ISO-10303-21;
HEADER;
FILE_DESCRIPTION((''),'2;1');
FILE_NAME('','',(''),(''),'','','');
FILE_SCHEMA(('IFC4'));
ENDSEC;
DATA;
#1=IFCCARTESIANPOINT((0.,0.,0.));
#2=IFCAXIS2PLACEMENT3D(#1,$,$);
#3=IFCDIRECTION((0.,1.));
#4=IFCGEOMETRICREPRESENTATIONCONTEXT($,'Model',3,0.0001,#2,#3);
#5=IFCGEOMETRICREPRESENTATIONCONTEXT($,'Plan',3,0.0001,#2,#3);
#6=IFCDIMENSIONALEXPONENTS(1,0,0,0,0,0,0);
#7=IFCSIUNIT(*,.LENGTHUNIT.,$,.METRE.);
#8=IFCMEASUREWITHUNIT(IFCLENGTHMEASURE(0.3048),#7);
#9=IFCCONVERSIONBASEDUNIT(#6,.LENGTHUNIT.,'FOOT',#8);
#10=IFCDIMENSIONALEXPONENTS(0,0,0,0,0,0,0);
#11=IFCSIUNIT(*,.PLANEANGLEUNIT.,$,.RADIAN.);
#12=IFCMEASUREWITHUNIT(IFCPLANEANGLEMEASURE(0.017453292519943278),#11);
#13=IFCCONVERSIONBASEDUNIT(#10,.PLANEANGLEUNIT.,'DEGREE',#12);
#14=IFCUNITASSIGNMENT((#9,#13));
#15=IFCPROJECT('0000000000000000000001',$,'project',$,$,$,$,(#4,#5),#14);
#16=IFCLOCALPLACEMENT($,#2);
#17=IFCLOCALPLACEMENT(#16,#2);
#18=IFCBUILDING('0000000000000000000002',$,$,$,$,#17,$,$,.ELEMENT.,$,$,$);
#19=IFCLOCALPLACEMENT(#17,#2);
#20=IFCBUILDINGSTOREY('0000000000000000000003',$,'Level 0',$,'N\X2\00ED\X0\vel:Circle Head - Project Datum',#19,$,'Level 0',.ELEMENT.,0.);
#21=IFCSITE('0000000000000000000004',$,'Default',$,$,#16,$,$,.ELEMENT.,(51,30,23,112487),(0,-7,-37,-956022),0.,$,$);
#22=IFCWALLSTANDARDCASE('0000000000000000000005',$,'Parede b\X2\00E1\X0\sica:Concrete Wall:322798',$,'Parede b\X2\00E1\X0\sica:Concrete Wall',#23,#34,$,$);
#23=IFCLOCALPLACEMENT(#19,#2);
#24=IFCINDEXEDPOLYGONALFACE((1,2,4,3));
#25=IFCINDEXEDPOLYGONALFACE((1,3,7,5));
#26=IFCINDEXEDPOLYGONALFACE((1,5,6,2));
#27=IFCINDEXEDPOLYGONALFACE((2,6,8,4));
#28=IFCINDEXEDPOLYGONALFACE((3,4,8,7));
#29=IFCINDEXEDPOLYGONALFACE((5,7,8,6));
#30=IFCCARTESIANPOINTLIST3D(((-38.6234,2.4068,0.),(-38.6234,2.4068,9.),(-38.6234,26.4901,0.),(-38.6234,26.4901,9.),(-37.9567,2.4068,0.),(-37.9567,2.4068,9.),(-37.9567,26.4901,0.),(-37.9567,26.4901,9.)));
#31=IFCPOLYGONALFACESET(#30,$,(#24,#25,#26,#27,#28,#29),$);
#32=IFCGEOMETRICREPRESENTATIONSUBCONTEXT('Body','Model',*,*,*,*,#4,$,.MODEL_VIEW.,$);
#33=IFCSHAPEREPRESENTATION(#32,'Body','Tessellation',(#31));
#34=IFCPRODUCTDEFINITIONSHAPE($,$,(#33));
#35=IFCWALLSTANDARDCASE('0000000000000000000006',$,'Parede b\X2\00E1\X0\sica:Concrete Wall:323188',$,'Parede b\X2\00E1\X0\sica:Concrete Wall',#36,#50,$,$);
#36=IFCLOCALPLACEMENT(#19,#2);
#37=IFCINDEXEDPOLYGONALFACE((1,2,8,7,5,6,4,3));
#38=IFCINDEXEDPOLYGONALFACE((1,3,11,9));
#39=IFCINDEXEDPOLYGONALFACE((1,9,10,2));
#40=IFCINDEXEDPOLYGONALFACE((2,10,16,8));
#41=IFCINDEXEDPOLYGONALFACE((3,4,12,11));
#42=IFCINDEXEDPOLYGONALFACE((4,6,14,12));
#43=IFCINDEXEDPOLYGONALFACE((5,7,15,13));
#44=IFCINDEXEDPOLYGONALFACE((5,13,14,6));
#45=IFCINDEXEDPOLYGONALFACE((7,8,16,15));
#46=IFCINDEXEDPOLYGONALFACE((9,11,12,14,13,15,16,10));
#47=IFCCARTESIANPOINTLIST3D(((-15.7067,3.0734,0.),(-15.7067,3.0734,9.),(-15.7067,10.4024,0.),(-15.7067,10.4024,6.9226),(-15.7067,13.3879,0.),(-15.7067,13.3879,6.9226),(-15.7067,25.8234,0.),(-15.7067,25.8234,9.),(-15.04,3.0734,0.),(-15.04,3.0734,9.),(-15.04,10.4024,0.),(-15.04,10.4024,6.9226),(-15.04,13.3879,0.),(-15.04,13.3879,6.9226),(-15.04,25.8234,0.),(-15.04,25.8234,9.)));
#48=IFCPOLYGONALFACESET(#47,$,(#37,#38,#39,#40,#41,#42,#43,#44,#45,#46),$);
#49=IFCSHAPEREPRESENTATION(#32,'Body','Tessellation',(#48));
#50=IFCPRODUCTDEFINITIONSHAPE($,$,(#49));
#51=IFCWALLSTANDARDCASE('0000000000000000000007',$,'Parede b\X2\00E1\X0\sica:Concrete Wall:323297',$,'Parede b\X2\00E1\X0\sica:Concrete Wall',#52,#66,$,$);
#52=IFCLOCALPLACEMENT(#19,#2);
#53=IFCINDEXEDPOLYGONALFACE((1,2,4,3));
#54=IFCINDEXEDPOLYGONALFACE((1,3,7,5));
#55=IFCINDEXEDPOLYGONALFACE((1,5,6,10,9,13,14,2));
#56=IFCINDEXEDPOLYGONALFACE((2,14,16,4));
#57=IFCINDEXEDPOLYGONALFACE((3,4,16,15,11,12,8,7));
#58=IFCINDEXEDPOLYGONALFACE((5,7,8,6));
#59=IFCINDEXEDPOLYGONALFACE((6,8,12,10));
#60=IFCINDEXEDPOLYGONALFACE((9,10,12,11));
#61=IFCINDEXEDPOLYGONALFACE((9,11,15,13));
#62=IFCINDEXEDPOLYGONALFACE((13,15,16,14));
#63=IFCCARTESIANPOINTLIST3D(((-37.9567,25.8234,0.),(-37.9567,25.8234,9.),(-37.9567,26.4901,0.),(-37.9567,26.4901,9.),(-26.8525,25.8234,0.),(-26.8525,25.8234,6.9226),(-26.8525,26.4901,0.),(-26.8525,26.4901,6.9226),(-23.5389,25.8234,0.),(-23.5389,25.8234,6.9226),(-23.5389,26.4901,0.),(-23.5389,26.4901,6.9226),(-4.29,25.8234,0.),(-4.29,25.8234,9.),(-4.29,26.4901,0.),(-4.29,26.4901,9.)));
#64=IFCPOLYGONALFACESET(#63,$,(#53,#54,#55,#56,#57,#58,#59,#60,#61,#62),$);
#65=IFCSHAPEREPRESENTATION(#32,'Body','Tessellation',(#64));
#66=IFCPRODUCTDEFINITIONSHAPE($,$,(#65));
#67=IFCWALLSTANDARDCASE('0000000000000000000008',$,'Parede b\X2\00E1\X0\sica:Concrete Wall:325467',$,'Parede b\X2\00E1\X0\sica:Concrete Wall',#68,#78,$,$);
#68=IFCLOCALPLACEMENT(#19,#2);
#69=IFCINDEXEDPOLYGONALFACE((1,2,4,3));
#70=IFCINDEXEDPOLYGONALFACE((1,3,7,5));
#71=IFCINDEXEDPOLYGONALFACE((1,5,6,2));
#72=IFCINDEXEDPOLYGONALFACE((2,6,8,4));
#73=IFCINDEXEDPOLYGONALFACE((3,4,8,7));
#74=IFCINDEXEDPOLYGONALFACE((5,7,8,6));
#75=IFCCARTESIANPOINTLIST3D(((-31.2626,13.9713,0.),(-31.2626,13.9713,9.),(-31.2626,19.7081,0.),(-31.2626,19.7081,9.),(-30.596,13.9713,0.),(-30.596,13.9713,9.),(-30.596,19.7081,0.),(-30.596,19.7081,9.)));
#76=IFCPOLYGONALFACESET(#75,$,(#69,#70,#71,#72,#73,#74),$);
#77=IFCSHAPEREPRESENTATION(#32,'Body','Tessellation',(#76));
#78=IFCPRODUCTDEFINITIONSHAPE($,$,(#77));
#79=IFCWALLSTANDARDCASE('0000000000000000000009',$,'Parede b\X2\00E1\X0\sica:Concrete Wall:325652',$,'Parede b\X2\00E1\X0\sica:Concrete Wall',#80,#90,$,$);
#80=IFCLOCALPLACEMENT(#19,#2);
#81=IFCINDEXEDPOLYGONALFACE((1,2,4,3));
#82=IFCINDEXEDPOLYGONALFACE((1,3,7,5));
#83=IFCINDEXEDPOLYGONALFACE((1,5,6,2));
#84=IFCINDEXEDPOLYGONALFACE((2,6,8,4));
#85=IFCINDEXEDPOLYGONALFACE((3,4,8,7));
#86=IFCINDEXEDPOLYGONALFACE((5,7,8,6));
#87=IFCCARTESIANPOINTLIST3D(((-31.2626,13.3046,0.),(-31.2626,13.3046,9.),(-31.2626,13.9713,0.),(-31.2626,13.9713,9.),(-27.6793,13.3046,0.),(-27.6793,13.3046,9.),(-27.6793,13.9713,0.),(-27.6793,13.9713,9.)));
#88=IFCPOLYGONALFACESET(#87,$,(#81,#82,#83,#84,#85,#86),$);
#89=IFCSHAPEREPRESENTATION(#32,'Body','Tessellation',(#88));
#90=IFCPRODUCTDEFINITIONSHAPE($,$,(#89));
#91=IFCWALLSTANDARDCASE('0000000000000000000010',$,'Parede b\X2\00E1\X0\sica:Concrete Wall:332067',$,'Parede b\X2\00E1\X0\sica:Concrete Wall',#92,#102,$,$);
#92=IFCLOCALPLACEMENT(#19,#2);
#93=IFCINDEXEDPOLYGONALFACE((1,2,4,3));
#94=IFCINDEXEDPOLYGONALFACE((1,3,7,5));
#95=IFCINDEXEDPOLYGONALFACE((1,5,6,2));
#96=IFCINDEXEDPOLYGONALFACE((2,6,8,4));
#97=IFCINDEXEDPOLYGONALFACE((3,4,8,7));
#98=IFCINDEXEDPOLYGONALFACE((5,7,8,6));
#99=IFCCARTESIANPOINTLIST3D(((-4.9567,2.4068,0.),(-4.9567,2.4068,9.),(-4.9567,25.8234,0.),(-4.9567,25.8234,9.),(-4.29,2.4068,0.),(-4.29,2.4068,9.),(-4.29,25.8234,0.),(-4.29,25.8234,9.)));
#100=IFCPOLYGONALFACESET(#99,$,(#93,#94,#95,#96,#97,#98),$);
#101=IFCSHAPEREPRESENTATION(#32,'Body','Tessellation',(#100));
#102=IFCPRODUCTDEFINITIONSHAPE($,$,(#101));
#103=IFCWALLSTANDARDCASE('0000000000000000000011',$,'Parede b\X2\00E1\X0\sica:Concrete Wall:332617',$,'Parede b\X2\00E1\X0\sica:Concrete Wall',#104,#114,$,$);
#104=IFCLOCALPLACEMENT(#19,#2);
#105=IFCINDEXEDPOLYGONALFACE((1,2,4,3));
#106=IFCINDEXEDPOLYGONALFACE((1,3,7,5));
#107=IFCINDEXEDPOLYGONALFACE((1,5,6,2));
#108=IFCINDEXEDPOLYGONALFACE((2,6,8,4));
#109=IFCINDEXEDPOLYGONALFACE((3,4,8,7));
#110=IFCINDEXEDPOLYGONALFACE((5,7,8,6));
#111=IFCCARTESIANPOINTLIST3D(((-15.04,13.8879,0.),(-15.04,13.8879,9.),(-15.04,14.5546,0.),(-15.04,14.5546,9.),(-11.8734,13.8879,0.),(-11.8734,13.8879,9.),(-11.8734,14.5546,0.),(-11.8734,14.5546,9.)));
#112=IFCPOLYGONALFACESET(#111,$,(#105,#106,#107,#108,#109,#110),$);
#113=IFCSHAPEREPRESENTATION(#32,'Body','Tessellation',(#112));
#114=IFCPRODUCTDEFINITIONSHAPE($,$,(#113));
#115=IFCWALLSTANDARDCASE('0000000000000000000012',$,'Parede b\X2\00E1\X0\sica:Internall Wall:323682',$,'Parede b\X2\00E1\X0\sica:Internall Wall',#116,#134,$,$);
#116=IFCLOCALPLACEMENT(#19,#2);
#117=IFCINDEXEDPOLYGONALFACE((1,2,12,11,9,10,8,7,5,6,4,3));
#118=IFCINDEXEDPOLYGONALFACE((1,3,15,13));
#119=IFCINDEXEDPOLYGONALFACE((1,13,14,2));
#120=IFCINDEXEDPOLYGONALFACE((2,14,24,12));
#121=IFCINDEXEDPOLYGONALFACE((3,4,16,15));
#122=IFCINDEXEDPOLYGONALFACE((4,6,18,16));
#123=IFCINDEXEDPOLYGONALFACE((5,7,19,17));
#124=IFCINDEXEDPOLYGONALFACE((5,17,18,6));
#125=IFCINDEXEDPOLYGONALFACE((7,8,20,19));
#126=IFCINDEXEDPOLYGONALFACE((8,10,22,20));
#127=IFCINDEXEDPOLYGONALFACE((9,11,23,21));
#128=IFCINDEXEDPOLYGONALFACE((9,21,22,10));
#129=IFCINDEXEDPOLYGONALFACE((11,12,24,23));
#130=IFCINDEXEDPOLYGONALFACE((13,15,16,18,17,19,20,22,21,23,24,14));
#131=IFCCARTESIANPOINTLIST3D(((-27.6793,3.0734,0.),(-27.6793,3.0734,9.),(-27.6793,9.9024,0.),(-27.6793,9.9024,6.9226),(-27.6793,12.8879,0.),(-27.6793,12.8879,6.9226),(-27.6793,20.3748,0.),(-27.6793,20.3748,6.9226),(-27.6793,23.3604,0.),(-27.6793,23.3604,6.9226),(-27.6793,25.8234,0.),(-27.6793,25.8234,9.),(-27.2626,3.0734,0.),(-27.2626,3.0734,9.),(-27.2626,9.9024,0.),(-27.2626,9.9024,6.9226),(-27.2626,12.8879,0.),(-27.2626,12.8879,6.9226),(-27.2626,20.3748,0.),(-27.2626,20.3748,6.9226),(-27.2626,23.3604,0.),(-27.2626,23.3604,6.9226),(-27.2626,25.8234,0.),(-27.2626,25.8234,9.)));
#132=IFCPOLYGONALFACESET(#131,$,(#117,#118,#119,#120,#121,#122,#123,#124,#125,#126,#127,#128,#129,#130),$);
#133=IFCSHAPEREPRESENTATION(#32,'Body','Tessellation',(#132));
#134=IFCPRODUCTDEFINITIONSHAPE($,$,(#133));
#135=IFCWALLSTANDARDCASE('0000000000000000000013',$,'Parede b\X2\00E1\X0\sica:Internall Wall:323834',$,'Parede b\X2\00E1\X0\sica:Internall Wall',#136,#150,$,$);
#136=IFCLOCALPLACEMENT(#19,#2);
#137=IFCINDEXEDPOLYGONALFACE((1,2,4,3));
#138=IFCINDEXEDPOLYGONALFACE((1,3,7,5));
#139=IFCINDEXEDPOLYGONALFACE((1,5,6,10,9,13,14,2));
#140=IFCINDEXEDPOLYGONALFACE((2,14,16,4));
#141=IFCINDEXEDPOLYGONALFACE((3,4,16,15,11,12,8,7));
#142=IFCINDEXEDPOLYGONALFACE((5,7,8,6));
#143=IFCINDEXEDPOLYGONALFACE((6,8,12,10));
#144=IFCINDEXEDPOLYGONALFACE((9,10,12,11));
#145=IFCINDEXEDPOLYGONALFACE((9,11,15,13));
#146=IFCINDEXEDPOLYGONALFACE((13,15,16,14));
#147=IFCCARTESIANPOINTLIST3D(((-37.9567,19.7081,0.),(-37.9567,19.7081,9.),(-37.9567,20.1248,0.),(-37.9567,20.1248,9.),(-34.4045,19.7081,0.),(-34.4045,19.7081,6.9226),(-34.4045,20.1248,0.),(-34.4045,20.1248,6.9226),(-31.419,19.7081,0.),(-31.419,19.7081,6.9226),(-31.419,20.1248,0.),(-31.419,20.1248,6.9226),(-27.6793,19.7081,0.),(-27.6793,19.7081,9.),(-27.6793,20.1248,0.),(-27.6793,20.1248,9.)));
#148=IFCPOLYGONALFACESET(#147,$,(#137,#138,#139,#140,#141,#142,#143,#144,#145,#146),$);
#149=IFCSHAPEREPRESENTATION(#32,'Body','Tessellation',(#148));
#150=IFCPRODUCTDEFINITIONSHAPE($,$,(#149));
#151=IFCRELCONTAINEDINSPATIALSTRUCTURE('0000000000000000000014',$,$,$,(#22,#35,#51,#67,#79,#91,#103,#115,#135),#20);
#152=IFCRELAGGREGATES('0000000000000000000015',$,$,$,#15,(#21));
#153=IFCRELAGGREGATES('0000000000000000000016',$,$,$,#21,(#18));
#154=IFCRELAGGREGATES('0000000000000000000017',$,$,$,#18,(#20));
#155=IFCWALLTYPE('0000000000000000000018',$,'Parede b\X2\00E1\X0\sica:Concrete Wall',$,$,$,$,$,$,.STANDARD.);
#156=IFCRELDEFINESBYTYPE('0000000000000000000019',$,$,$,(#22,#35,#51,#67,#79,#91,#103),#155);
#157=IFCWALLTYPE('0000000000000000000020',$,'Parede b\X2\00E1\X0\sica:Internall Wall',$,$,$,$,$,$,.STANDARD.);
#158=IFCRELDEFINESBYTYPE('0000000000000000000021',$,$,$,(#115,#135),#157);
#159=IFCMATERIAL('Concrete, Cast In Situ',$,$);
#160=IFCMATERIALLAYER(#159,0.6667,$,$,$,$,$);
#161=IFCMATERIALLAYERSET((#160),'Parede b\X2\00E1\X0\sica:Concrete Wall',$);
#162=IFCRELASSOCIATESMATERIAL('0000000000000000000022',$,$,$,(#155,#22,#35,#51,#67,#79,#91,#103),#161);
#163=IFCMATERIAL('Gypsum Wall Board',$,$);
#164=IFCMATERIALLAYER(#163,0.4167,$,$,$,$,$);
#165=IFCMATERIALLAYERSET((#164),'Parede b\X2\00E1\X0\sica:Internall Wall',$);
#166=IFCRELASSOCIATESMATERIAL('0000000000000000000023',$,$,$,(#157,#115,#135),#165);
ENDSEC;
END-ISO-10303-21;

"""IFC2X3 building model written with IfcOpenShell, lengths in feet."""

from ifc_helpers import new_model, entity, si_unit, converted_unit, direction, frame, frame_2d, origin, place, context, subcontext, project, spatial, rectangle, extrude, material, layer, layer_set, layer_usage, type_object, element, save


model = new_model("IFC2X3")

# Units and contexts
model_context = context("Model", 3, precision=0.0001, world=origin(), true_north=direction((0.0, 1.0)))
plan_context = context("Plan", 3, precision=0.0001, world=origin(), true_north=direction((0.0, 1.0)))
body_context = subcontext(model_context, "Body", "Model", "MODEL_VIEW")
ifc_project = project(units=[converted_unit("LENGTHUNIT", "FOOT", entity("IfcLengthMeasure", 0.3048), si_unit("LENGTHUNIT", "METRE"), dimensions=[1, 0, 0, 0, 0, 0, 0]), converted_unit("PLANEANGLEUNIT", "DEGREE", entity("IfcPlaneAngleMeasure", 0.017453292519943278), si_unit("PLANEANGLEUNIT", "RADIAN"), dimensions=[0, 0, 0, 0, 0, 0, 0])], contexts=[model_context, plan_context])

# Site, building, storey
site_placement = place(None, origin())
site = spatial("IfcSite", under=ifc_project, at=site_placement, Name="Default", CompositionType="ELEMENT", RefLatitude=(51, 30, 23, 112487), RefLongitude=(0, -7, -37, -956022), RefElevation=0.0)
building_placement = place(site_placement, origin())
building = spatial("IfcBuilding", under=site, at=building_placement, CompositionType="ELEMENT")
storey_placement = place(building_placement, origin())
storey = spatial("IfcBuildingStorey", under=building, at=storey_placement, Name="Level 0", ObjectType="Nível:Circle Head - Project Datum", LongName="Level 0", CompositionType="ELEMENT", Elevation=0.0)

# Wall
ifc_material_1 = material(Name="Concrete, Cast In Situ")
ifc_layer_1 = layer(ifc_material_1, 0.6667)
ifc_layer_set_1 = layer_set([ifc_layer_1], Name="Parede básica:Concrete Wall")
ifc_layer_usage_1 = layer_usage(ifc_layer_set_1, "AXIS2", "POSITIVE", -0.3333)
wall_type_1 = type_object("IfcWallType", Name="Parede básica:Concrete Wall", PredefinedType="STANDARD", material=ifc_layer_set_1)
wall_1_placement = place(storey_placement, frame((-38.29, 26.4901, 0.0), z_axis=(0.0, 0.0, 1.0), x_axis=(0.0, -1.0, 0.0)))
element("IfcWallStandardCase", 1, at=wall_1_placement, inside=storey, type_object=wall_type_1, material=ifc_layer_usage_1, Name="Parede básica:Concrete Wall:322798", ObjectType="Parede básica:Concrete Wall", context=body_context, shape_type="SweptSolid", body=[
    extrude(rectangle(XDim=24.0833, YDim=0.6667, at=frame_2d((12.0417, 0.0), x_axis=(-1.0, 0.0))), origin(), (0.0, 0.0, 1.0), 9.0),
])

# Walls, openings
ifc_layer_usage_2 = layer_usage(ifc_layer_set_1, "AXIS2", "POSITIVE", -0.3333)
wall_2_placement = place(storey_placement, frame((-15.3734, 3.0734, 0.0), z_axis=(0.0, 0.0, 1.0), x_axis=(0.0, 1.0, 0.0)))
wall_2 = element("IfcWallStandardCase", 2, at=wall_2_placement, inside=storey, type_object=wall_type_1, material=ifc_layer_usage_2, Name="Parede básica:Concrete Wall:323188", ObjectType="Parede básica:Concrete Wall", context=body_context, shape_type="SweptSolid", body=[
    extrude(rectangle(XDim=22.75, YDim=0.6667, at=frame_2d((11.375, 0.0), x_axis=(1.0, 0.0))), origin(), (0.0, 0.0, 1.0), 9.0),
])
opening_1_placement = place(wall_2_placement, frame((10.3145, 0.3333, 0.0)))
element("IfcOpeningElement", 3, at=opening_1_placement, cuts=wall_2, ObjectType="Opening", context=body_context, shape_type="SweptSolid", body=[
    extrude(rectangle(XDim=6.9226, YDim=2.9856, at=frame_2d((3.4613, 1.4928), x_axis=(1.0, 0.0))), frame((0.0, 0.0, 0.0), z_axis=(0.0, -1.0, 0.0), x_axis=(0.0, 0.0, 1.0)), (0.0, 0.0, 1.0), 0.6667),
])
ifc_layer_usage_3 = layer_usage(ifc_layer_set_1, "AXIS2", "POSITIVE", -0.3333)
wall_3_placement = place(storey_placement, frame((-4.29, 26.1568, 0.0), z_axis=(0.0, 0.0, 1.0), x_axis=(-1.0, 0.0, 0.0)))
wall_3 = element("IfcWallStandardCase", 4, at=wall_3_placement, inside=storey, type_object=wall_type_1, material=ifc_layer_usage_3, Name="Parede básica:Concrete Wall:323297", ObjectType="Parede básica:Concrete Wall", context=body_context, shape_type="SweptSolid", body=[
    extrude(rectangle(XDim=33.6667, YDim=0.6667, at=frame_2d((16.8333, 0.0), x_axis=(1.0, 0.0))), origin(), (0.0, 0.0, 1.0), 9.0),
])
opening_2_placement = place(wall_3_placement, frame((19.2489, -0.3333, 0.0)))
element("IfcOpeningElement", 5, at=opening_2_placement, cuts=wall_3, ObjectType="Opening", context=body_context, shape_type="SweptSolid", body=[
    extrude(rectangle(XDim=6.9226, YDim=3.3136, at=frame_2d((3.4613, 1.6568), x_axis=(1.0, 0.0))), frame((0.0, 0.0, 0.0), z_axis=(0.0, 1.0, 0.0), x_axis=(0.0, 0.0, 1.0)), (0.0, 0.0, 1.0), 0.6667),
])

# Walls
ifc_layer_usage_4 = layer_usage(ifc_layer_set_1, "AXIS2", "POSITIVE", -0.3333)
wall_4_placement = place(storey_placement, frame((-30.9293, 19.7081, 0.0), z_axis=(0.0, 0.0, 1.0), x_axis=(0.0, -1.0, 0.0)))
element("IfcWallStandardCase", 6, at=wall_4_placement, inside=storey, type_object=wall_type_1, material=ifc_layer_usage_4, Name="Parede básica:Concrete Wall:325467", ObjectType="Parede básica:Concrete Wall", context=body_context, shape_type="SweptSolid", body=[
    extrude(rectangle(XDim=5.7369, YDim=0.6667, at=frame_2d((2.8684, 0.0), x_axis=(-1.0, 0.0))), origin(), (0.0, 0.0, 1.0), 9.0),
])
ifc_layer_usage_5 = layer_usage(ifc_layer_set_1, "AXIS2", "POSITIVE", -0.3333)
wall_5_placement = place(storey_placement, frame((-31.2626, 13.6379, 0.0)))
element("IfcWallStandardCase", 7, at=wall_5_placement, inside=storey, type_object=wall_type_1, material=ifc_layer_usage_5, Name="Parede básica:Concrete Wall:325652", ObjectType="Parede básica:Concrete Wall", context=body_context, shape_type="SweptSolid", body=[
    extrude(rectangle(XDim=3.5833, YDim=0.6667, at=frame_2d((1.7917, 0.0), x_axis=(-1.0, 0.0))), origin(), (0.0, 0.0, 1.0), 9.0),
])
ifc_layer_usage_6 = layer_usage(ifc_layer_set_1, "AXIS2", "POSITIVE", -0.3333)
wall_6_placement = place(storey_placement, frame((-4.6234, 2.4068, 0.0), z_axis=(0.0, 0.0, 1.0), x_axis=(0.0, 1.0, 0.0)))
element("IfcWallStandardCase", 8, at=wall_6_placement, inside=storey, type_object=wall_type_1, material=ifc_layer_usage_6, Name="Parede básica:Concrete Wall:332067", ObjectType="Parede básica:Concrete Wall", context=body_context, shape_type="SweptSolid", body=[
    extrude(rectangle(XDim=23.4167, YDim=0.6667, at=frame_2d((11.7083, 0.0), x_axis=(-1.0, 0.0))), origin(), (0.0, 0.0, 1.0), 9.0),
])
ifc_layer_usage_7 = layer_usage(ifc_layer_set_1, "AXIS2", "POSITIVE", -0.3333)
wall_7_placement = place(storey_placement, frame((-15.04, 14.2213, 0.0)))
element("IfcWallStandardCase", 9, at=wall_7_placement, inside=storey, type_object=wall_type_1, material=ifc_layer_usage_7, Name="Parede básica:Concrete Wall:332617", ObjectType="Parede básica:Concrete Wall", context=body_context, shape_type="SweptSolid", body=[
    extrude(rectangle(XDim=3.1667, YDim=0.6667, at=frame_2d((1.5833, 0.0), x_axis=(-1.0, 0.0))), origin(), (0.0, 0.0, 1.0), 9.0),
])

# Wall, openings
ifc_material_2 = material(Name="Gypsum Wall Board")
ifc_layer_2 = layer(ifc_material_2, 0.4167)
ifc_layer_set_2 = layer_set([ifc_layer_2], Name="Parede básica:Internall Wall")
ifc_layer_usage_8 = layer_usage(ifc_layer_set_2, "AXIS2", "NEGATIVE", 0.2083)
wall_type_2 = type_object("IfcWallType", Name="Parede básica:Internall Wall", PredefinedType="STANDARD", material=ifc_layer_set_2)
wall_8_placement = place(storey_placement, frame((-27.471, 3.0734, 0.0), z_axis=(0.0, 0.0, 1.0), x_axis=(0.0, 1.0, 0.0)))
wall_8 = element("IfcWallStandardCase", 10, at=wall_8_placement, inside=storey, type_object=wall_type_2, material=ifc_layer_usage_8, Name="Parede básica:Internall Wall:323682", ObjectType="Parede básica:Internall Wall", context=body_context, shape_type="SweptSolid", body=[
    extrude(rectangle(XDim=22.75, YDim=0.4167, at=frame_2d((11.375, 0.0), x_axis=(1.0, 0.0))), origin(), (0.0, 0.0, 1.0), 9.0),
])
opening_3_placement = place(wall_8_placement, frame((17.3014, -0.2083, 0.0)))
element("IfcOpeningElement", 11, at=opening_3_placement, cuts=wall_8, ObjectType="Opening", context=body_context, shape_type="SweptSolid", body=[
    extrude(rectangle(XDim=6.9226, YDim=2.9856, at=frame_2d((3.4613, 1.4928), x_axis=(1.0, 0.0))), frame((0.0, 0.0, 0.0), z_axis=(0.0, 1.0, 0.0), x_axis=(0.0, 0.0, 1.0)), (0.0, 0.0, 1.0), 0.4167),
])
opening_4_placement = place(wall_8_placement, frame((6.8289, -0.2083, 0.0)))
element("IfcOpeningElement", 12, at=opening_4_placement, cuts=wall_8, ObjectType="Opening", context=body_context, shape_type="SweptSolid", body=[
    extrude(rectangle(XDim=6.9226, YDim=2.9856, at=frame_2d((3.4613, 1.4928), x_axis=(1.0, 0.0))), frame((0.0, 0.0, 0.0), z_axis=(0.0, 1.0, 0.0), x_axis=(0.0, 0.0, 1.0)), (0.0, 0.0, 1.0), 0.4167),
])

# Wall, opening
ifc_layer_usage_9 = layer_usage(ifc_layer_set_2, "AXIS2", "NEGATIVE", 0.2083)
wall_9_placement = place(storey_placement, frame((-37.9567, 19.9165, 0.0)))
wall_9 = element("IfcWallStandardCase", 13, at=wall_9_placement, inside=storey, type_object=wall_type_2, material=ifc_layer_usage_9, Name="Parede básica:Internall Wall:323834", ObjectType="Parede básica:Internall Wall", context=body_context, shape_type="SweptSolid", body=[
    extrude(rectangle(XDim=10.2774, YDim=0.4167, at=frame_2d((5.1387, 0.0), x_axis=(1.0, 0.0))), origin(), (0.0, 0.0, 1.0), 9.0),
])
opening_5_placement = place(wall_9_placement, frame((6.5377, 0.2083, 0.0)))
element("IfcOpeningElement", 14, at=opening_5_placement, cuts=wall_9, ObjectType="Opening", context=body_context, shape_type="SweptSolid", body=[
    extrude(rectangle(XDim=6.9226, YDim=2.9856, at=frame_2d((3.4613, 1.4928), x_axis=(1.0, 0.0))), frame((0.0, 0.0, 0.0), z_axis=(0.0, -1.0, 0.0), x_axis=(0.0, 0.0, 1.0)), (0.0, 0.0, 1.0), 0.4167),
])

save(model, "model.ifc")
